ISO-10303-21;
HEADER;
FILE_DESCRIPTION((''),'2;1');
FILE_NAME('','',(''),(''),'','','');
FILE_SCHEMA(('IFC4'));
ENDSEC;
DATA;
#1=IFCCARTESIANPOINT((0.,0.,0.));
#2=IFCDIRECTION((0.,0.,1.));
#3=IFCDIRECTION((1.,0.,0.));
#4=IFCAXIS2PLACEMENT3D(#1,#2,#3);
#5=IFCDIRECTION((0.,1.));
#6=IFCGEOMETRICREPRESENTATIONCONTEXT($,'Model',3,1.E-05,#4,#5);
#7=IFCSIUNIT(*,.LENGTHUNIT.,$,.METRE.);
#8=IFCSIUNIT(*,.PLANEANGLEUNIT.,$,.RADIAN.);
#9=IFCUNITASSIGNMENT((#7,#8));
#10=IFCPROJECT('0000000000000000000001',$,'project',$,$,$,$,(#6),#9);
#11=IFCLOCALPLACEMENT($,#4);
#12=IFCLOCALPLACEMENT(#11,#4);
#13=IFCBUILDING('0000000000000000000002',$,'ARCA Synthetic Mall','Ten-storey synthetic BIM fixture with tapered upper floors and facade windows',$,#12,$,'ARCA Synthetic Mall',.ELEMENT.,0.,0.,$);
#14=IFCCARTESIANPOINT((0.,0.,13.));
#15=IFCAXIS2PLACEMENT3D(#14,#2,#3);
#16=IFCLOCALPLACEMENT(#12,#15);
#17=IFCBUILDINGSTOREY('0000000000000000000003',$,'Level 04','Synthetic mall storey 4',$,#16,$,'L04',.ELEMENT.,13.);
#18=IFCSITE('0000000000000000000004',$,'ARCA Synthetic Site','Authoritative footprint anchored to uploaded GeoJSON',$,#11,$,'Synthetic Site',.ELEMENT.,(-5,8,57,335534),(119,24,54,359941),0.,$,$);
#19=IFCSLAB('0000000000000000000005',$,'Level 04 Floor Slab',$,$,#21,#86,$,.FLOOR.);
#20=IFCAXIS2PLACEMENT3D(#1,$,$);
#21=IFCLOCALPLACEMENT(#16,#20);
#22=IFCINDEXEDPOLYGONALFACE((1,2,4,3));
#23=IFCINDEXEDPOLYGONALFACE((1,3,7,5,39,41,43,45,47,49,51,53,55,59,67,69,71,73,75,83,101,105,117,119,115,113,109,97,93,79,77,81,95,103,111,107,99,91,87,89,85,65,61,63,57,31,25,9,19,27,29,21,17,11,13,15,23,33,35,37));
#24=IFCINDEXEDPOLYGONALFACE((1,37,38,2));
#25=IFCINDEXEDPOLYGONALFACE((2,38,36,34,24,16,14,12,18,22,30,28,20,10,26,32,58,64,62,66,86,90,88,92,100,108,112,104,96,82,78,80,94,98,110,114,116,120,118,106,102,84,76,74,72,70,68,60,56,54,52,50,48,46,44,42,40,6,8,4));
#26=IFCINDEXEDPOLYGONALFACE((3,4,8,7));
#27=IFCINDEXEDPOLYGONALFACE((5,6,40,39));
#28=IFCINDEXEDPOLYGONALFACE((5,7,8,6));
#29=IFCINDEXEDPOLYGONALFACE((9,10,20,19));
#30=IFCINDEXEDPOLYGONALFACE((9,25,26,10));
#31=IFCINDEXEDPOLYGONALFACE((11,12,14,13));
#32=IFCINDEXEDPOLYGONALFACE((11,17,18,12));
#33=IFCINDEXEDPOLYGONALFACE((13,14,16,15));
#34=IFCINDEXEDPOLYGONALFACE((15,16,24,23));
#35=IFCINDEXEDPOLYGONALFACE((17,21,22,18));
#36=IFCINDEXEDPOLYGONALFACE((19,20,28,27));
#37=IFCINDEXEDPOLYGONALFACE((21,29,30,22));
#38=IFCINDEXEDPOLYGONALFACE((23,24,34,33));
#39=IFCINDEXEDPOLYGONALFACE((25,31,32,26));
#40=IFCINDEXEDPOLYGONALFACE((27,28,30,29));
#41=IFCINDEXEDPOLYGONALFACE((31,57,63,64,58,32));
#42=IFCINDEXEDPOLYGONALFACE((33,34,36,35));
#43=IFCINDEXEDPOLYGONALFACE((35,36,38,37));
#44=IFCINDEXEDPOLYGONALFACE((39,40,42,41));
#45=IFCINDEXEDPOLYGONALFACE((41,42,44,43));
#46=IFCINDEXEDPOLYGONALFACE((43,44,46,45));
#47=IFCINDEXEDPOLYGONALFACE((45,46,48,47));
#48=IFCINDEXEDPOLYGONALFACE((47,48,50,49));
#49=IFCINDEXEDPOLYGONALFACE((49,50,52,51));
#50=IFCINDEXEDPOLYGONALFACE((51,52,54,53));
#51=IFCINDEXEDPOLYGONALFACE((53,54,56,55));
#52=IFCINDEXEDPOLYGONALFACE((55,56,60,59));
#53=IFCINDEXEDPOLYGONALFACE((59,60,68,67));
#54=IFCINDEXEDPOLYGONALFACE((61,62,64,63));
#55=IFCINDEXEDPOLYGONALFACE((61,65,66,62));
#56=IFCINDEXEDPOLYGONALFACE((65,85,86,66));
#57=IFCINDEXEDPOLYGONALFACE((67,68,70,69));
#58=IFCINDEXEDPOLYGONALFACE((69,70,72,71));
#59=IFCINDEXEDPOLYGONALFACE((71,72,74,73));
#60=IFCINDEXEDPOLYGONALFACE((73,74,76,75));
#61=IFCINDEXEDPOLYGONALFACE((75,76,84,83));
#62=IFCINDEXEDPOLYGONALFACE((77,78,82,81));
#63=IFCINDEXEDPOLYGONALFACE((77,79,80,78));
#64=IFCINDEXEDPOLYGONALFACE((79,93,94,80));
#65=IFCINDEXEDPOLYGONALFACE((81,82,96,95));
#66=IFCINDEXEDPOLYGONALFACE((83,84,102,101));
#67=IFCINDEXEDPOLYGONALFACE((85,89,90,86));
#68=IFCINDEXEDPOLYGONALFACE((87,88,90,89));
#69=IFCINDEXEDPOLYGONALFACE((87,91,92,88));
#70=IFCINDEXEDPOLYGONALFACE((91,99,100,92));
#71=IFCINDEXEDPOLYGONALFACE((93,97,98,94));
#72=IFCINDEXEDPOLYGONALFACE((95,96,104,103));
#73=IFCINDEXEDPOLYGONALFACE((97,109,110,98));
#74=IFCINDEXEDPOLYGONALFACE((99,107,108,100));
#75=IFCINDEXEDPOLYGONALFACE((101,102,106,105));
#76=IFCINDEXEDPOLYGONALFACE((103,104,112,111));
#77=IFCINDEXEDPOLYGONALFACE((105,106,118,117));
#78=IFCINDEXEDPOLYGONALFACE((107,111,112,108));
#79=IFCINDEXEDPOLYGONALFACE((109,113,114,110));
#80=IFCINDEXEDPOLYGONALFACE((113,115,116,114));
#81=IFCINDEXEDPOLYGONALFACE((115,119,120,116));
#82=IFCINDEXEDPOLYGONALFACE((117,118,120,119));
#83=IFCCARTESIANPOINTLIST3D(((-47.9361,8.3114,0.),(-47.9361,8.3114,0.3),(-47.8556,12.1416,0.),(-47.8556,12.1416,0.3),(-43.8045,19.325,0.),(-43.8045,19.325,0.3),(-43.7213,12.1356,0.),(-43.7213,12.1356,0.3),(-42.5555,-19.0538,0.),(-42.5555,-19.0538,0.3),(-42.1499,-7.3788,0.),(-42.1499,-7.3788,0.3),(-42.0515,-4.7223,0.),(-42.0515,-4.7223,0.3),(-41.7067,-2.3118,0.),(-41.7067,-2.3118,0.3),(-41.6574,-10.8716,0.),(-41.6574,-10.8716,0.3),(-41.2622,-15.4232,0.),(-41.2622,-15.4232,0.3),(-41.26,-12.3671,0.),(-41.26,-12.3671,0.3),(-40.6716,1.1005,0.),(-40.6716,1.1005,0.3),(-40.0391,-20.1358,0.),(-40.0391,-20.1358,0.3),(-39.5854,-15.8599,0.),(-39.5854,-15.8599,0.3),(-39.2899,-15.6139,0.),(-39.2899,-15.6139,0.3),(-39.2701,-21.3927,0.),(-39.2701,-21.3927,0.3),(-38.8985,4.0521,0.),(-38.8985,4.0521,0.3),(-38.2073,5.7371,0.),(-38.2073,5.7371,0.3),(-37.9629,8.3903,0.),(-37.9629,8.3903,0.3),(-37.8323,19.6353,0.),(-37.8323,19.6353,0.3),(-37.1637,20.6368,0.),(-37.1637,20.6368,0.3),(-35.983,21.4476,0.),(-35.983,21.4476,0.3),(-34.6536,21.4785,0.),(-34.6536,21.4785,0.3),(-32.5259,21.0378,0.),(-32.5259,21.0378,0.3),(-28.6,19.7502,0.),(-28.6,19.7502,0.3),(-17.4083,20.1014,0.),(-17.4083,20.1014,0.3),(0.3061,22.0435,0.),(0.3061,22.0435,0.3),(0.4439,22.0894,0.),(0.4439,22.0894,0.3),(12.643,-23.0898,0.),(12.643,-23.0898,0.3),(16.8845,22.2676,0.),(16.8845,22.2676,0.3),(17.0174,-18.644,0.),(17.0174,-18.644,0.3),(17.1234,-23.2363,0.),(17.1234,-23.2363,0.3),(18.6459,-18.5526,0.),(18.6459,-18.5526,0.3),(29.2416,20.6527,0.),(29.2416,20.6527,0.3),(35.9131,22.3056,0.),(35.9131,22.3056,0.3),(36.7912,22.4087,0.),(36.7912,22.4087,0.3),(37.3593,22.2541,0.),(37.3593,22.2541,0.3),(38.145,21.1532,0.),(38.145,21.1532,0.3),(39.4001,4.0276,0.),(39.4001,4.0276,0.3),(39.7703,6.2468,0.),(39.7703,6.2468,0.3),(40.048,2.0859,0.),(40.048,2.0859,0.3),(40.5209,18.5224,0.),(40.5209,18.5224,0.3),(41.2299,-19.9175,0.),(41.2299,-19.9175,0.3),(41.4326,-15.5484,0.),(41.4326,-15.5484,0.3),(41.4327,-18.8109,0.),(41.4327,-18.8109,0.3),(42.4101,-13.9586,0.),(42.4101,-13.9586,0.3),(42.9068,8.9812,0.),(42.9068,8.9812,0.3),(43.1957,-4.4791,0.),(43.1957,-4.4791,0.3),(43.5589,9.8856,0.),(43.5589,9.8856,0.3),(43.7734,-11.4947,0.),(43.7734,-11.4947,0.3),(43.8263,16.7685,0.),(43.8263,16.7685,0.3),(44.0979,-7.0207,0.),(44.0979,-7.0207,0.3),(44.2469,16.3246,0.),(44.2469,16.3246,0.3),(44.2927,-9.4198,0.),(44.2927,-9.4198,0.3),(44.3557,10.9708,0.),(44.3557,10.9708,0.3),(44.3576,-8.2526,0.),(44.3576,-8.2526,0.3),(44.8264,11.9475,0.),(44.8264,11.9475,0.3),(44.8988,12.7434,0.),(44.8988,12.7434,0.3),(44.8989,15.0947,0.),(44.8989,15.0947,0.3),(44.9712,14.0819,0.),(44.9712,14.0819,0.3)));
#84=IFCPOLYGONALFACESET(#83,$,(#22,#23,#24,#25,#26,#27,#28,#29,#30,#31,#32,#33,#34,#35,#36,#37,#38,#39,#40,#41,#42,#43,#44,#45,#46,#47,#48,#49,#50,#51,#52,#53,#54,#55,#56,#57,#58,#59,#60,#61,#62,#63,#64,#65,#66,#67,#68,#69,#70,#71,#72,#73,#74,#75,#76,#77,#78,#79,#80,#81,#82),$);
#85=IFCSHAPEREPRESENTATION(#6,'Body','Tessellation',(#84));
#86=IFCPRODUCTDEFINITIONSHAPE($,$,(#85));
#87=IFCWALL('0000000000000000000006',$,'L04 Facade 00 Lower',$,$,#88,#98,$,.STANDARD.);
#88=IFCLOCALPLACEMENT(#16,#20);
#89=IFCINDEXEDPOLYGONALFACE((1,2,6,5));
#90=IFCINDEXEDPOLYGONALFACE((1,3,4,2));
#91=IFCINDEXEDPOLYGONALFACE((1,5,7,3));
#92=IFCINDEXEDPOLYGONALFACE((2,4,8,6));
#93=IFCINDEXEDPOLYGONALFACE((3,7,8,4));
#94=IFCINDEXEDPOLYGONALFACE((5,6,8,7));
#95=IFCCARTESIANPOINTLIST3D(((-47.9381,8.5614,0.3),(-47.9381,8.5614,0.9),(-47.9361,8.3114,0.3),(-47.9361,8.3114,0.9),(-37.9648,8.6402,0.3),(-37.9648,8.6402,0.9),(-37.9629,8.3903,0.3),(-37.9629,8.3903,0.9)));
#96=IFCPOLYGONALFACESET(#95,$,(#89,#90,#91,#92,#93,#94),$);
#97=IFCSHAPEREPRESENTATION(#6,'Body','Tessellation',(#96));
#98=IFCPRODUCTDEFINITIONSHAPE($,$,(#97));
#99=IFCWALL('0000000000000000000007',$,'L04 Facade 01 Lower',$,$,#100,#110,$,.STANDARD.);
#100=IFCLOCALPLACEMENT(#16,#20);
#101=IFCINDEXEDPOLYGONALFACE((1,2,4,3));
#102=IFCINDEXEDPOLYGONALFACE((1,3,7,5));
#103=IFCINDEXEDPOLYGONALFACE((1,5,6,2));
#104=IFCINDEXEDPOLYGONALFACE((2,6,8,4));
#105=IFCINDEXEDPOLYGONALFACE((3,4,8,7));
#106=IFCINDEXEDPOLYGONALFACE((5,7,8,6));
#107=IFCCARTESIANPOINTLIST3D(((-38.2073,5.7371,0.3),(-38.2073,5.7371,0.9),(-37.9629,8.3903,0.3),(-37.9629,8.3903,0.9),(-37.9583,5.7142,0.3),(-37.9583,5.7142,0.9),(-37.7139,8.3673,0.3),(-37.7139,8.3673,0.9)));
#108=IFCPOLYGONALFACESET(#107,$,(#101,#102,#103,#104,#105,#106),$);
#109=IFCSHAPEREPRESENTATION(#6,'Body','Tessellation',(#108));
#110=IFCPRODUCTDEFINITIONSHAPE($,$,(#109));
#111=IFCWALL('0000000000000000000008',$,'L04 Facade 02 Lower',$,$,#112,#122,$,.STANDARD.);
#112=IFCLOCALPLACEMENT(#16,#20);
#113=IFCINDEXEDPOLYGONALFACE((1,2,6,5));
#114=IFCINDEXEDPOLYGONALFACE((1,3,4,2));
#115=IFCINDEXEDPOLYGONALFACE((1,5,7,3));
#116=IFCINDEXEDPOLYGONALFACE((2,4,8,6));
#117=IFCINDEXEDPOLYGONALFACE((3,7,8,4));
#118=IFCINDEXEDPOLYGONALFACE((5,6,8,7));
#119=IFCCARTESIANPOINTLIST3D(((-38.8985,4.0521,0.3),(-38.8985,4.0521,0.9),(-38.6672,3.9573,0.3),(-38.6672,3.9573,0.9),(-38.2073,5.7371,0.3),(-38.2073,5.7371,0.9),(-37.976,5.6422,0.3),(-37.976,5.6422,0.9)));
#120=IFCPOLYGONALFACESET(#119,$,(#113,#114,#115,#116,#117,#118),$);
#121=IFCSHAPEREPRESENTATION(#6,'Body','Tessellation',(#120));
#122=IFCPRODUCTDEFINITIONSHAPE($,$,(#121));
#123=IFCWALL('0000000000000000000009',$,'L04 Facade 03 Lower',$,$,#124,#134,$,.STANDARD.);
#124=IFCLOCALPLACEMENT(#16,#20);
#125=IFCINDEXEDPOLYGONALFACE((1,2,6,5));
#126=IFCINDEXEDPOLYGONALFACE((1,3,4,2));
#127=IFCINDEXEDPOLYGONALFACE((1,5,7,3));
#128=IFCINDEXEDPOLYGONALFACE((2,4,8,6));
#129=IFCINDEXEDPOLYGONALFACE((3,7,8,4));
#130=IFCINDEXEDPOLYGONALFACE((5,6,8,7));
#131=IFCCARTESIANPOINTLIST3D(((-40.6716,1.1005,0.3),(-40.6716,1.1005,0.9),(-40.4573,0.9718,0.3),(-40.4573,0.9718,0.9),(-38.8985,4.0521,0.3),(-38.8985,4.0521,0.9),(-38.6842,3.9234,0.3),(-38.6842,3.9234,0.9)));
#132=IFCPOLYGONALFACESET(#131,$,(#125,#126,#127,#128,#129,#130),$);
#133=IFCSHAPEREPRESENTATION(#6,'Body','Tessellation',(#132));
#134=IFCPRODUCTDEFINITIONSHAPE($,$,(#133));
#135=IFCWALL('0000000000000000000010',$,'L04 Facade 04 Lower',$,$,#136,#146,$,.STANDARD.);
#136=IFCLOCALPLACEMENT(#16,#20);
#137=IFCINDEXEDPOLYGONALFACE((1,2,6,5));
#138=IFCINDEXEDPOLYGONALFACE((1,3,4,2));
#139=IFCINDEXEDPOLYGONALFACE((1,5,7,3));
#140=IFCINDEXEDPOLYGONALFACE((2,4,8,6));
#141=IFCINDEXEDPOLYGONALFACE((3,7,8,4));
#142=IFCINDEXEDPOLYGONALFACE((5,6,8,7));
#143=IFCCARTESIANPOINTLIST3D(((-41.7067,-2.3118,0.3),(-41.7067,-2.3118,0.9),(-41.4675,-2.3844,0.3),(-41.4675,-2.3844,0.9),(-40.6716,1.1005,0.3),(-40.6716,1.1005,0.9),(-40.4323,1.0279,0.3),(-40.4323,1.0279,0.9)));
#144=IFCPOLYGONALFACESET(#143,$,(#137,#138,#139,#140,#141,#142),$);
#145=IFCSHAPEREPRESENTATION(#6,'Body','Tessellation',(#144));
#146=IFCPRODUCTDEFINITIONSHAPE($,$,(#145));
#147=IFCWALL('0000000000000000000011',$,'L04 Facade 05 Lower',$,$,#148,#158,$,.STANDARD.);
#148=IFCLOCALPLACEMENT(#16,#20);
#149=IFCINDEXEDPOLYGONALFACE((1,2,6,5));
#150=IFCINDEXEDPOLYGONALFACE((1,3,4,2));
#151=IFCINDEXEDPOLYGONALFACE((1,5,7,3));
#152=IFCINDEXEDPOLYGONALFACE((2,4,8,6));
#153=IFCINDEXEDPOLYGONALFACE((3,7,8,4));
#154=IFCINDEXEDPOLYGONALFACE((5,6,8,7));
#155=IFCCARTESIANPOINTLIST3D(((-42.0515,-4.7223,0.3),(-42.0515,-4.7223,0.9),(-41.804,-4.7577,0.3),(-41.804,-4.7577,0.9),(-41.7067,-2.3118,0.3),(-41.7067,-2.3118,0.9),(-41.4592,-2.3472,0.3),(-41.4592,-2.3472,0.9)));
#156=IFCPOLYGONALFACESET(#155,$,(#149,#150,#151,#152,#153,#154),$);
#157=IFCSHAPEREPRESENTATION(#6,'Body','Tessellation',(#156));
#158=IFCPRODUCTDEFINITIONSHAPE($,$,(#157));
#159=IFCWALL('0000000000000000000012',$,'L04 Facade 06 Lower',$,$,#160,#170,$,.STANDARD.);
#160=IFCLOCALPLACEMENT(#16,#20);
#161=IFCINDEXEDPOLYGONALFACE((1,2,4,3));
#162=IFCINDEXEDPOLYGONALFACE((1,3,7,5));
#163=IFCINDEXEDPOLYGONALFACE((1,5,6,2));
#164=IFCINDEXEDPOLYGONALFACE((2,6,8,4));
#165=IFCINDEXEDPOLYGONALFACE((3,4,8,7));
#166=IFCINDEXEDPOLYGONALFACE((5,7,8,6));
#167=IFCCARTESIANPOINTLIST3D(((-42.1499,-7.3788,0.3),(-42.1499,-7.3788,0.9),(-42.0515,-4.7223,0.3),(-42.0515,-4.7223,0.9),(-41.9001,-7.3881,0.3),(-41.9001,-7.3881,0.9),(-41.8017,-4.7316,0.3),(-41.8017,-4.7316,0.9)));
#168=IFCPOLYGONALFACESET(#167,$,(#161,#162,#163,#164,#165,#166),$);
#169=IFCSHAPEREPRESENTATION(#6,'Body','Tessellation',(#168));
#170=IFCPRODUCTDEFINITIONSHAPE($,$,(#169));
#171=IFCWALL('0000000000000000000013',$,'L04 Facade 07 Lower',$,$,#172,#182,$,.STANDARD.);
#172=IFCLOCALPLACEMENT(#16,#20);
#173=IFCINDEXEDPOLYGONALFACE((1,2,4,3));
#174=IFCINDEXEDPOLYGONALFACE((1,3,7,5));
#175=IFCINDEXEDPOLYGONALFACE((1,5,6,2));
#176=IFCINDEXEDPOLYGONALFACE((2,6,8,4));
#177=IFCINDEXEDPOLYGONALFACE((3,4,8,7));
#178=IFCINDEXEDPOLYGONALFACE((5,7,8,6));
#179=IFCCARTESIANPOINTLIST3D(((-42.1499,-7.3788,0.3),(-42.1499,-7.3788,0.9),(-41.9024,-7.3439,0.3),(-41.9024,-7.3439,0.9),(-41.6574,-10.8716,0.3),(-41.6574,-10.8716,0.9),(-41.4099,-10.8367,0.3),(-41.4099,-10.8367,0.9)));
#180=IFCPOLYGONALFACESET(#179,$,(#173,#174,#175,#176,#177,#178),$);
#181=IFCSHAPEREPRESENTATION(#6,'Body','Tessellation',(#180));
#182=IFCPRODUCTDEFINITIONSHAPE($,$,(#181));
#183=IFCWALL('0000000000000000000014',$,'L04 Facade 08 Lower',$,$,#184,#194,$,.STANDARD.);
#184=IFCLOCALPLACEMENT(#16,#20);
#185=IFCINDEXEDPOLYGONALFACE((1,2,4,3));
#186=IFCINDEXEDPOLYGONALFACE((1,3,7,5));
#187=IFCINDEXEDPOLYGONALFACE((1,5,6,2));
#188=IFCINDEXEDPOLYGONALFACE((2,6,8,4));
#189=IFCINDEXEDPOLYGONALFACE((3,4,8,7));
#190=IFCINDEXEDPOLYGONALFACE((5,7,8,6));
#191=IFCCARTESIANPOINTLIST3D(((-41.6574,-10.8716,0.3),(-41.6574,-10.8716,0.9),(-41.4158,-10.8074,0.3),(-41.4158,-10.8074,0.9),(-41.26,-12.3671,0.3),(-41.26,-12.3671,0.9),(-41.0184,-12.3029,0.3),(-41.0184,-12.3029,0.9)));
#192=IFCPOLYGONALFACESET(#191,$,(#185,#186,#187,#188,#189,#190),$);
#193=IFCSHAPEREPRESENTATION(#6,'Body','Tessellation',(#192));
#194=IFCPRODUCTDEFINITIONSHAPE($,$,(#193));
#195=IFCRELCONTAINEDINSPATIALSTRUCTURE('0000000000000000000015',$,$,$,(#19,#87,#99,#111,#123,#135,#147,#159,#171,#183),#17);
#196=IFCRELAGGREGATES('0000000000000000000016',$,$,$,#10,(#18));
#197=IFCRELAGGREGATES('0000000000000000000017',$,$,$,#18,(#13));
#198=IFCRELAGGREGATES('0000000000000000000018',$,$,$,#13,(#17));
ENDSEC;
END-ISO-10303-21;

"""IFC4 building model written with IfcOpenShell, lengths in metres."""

from ifc_helpers import new_model, si_unit, direction, frame, origin_with_axes, place, context, project, spatial, polyline, outline, extrude, element, save


model = new_model("IFC4")

# Units and contexts
model_context = context("Model", 3, precision=1e-05, world=origin_with_axes(), true_north=direction((0.0, 1.0)))
ifc_project = project(units=[si_unit("LENGTHUNIT", "METRE"), si_unit("PLANEANGLEUNIT", "RADIAN")], contexts=[model_context])

# Site, building, storey
site_placement = place(None, origin_with_axes())
site = spatial("IfcSite", under=ifc_project, at=site_placement, Name="ARCA Synthetic Site", Description="Authoritative footprint anchored to uploaded GeoJSON", LongName="Synthetic Site", CompositionType="ELEMENT", RefLatitude=(-5, 8, 57, 335534), RefLongitude=(119, 24, 54, 359941), RefElevation=0.0)
building_placement = place(site_placement, origin_with_axes())
building = spatial("IfcBuilding", under=site, at=building_placement, Name="ARCA Synthetic Mall", Description="Ten-storey synthetic BIM fixture with tapered upper floors and facade windows", LongName="ARCA Synthetic Mall", CompositionType="ELEMENT", ElevationOfRefHeight=0.0, ElevationOfTerrain=0.0)
storey_placement = place(building_placement, frame((0.0, 0.0, 13.0), z_axis=(0.0, 0.0, 1.0), x_axis=(1.0, 0.0, 0.0)))
storey = spatial("IfcBuildingStorey", under=building, at=storey_placement, Name="Level 04", Description="Synthetic mall storey 4", LongName="L04", CompositionType="ELEMENT", Elevation=13.0)

# Slab
slab_placement = place(storey_placement, origin_with_axes())
element("IfcSlab", 1, at=slab_placement, inside=storey, Name="Level 04 Floor Slab", PredefinedType="FLOOR", context=model_context, shape_type="SweptSolid", body=[
    extrude(outline(polyline([(-47.9361, 8.3114), (-37.9629, 8.3903), (-38.2073, 5.7371), (-38.8985, 4.0521), (-40.6716, 1.1005), (-41.7067, -2.3118), (-42.0515, -4.7223), (-42.1499, -7.3788), (-41.6574, -10.8716), (-41.26, -12.3671), (-39.2899, -15.6139), (-39.5854, -15.8599), (-41.2622, -15.4232), (-42.5555, -19.0538), (-40.0391, -20.1358), (-39.2701, -21.3927), (12.6431, -23.0898), (17.1234, -23.2363), (17.0174, -18.644), (18.6459, -18.5526), (41.2299, -19.9175), (41.4327, -18.8109), (41.4326, -15.5484), (42.4101, -13.9586), (43.7734, -11.4947), (44.2927, -9.4198), (44.3576, -8.2526), (44.0979, -7.0207), (43.1957, -4.4791), (40.048, 2.0859), (39.4001, 4.0276), (39.7703, 6.2468), (42.9068, 8.9812), (43.5589, 9.8856), (44.3557, 10.9708), (44.8264, 11.9475), (44.8988, 12.7434), (44.9712, 14.0819), (44.8989, 15.0947), (44.2469, 16.3246), (43.8263, 16.7685), (40.5209, 18.5224), (38.145, 21.1532), (37.3593, 22.2541), (36.7912, 22.4087), (35.9131, 22.3056), (29.2416, 20.6527), (16.8845, 22.2676), (0.4439, 22.0894), (0.3061, 22.0435), (-17.4083, 20.1014), (-28.6, 19.7502), (-32.5259, 21.0378), (-34.6536, 21.4785), (-35.983, 21.4475), (-37.1637, 20.6368), (-37.8323, 19.6353), (-43.8045, 19.325), (-43.7213, 12.1356), (-47.8556, 12.1416), (-47.9361, 8.3114)])), origin_with_axes(), (0.0, 0.0, 1.0), 0.3),
])

# Walls
wall_1_placement = place(storey_placement, frame((0.0, 0.0, 0.3), z_axis=(0.0, 0.0, 1.0), x_axis=(1.0, 0.0, 0.0)))
element("IfcWall", 2, at=wall_1_placement, inside=storey, Name="L04 Facade 00 Lower", PredefinedType="STANDARD", context=model_context, shape_type="SweptSolid", body=[
    extrude(outline(polyline([(-47.9361, 8.3114), (-37.9629, 8.3903), (-37.9648, 8.6402), (-47.9381, 8.5614), (-47.9361, 8.3114)])), origin_with_axes(), (0.0, 0.0, 1.0), 0.6),
])
wall_2_placement = place(storey_placement, frame((0.0, 0.0, 0.3), z_axis=(0.0, 0.0, 1.0), x_axis=(1.0, 0.0, 0.0)))
element("IfcWall", 3, at=wall_2_placement, inside=storey, Name="L04 Facade 01 Lower", PredefinedType="STANDARD", context=model_context, shape_type="SweptSolid", body=[
    extrude(outline(polyline([(-37.9629, 8.3903), (-38.2073, 5.7371), (-37.9583, 5.7142), (-37.7139, 8.3673), (-37.9629, 8.3903)])), origin_with_axes(), (0.0, 0.0, 1.0), 0.6),
])
wall_3_placement = place(storey_placement, frame((0.0, 0.0, 0.3), z_axis=(0.0, 0.0, 1.0), x_axis=(1.0, 0.0, 0.0)))
element("IfcWall", 4, at=wall_3_placement, inside=storey, Name="L04 Facade 02 Lower", PredefinedType="STANDARD", context=model_context, shape_type="SweptSolid", body=[
    extrude(outline(polyline([(-38.2073, 5.7371), (-38.8985, 4.0521), (-38.6672, 3.9573), (-37.976, 5.6422), (-38.2073, 5.7371)])), origin_with_axes(), (0.0, 0.0, 1.0), 0.6),
])
wall_4_placement = place(storey_placement, frame((0.0, 0.0, 0.3), z_axis=(0.0, 0.0, 1.0), x_axis=(1.0, 0.0, 0.0)))
element("IfcWall", 5, at=wall_4_placement, inside=storey, Name="L04 Facade 03 Lower", PredefinedType="STANDARD", context=model_context, shape_type="SweptSolid", body=[
    extrude(outline(polyline([(-38.8985, 4.0521), (-40.6716, 1.1005), (-40.4573, 0.9718), (-38.6842, 3.9234), (-38.8985, 4.0521)])), origin_with_axes(), (0.0, 0.0, 1.0), 0.6),
])
wall_5_placement = place(storey_placement, frame((0.0, 0.0, 0.3), z_axis=(0.0, 0.0, 1.0), x_axis=(1.0, 0.0, 0.0)))
element("IfcWall", 6, at=wall_5_placement, inside=storey, Name="L04 Facade 04 Lower", PredefinedType="STANDARD", context=model_context, shape_type="SweptSolid", body=[
    extrude(outline(polyline([(-40.6716, 1.1005), (-41.7067, -2.3118), (-41.4675, -2.3844), (-40.4323, 1.0279), (-40.6716, 1.1005)])), origin_with_axes(), (0.0, 0.0, 1.0), 0.6),
])
wall_6_placement = place(storey_placement, frame((0.0, 0.0, 0.3), z_axis=(0.0, 0.0, 1.0), x_axis=(1.0, 0.0, 0.0)))
element("IfcWall", 7, at=wall_6_placement, inside=storey, Name="L04 Facade 05 Lower", PredefinedType="STANDARD", context=model_context, shape_type="SweptSolid", body=[
    extrude(outline(polyline([(-41.7067, -2.3118), (-42.0515, -4.7223), (-41.804, -4.7577), (-41.4592, -2.3472), (-41.7067, -2.3118)])), origin_with_axes(), (0.0, 0.0, 1.0), 0.6),
])
wall_7_placement = place(storey_placement, frame((0.0, 0.0, 0.3), z_axis=(0.0, 0.0, 1.0), x_axis=(1.0, 0.0, 0.0)))
element("IfcWall", 8, at=wall_7_placement, inside=storey, Name="L04 Facade 06 Lower", PredefinedType="STANDARD", context=model_context, shape_type="SweptSolid", body=[
    extrude(outline(polyline([(-42.0515, -4.7223), (-42.1499, -7.3788), (-41.9001, -7.3881), (-41.8017, -4.7316), (-42.0515, -4.7223)])), origin_with_axes(), (0.0, 0.0, 1.0), 0.6),
])
wall_8_placement = place(storey_placement, frame((0.0, 0.0, 0.3), z_axis=(0.0, 0.0, 1.0), x_axis=(1.0, 0.0, 0.0)))
element("IfcWall", 9, at=wall_8_placement, inside=storey, Name="L04 Facade 07 Lower", PredefinedType="STANDARD", context=model_context, shape_type="SweptSolid", body=[
    extrude(outline(polyline([(-42.1499, -7.3788), (-41.6574, -10.8716), (-41.4099, -10.8367), (-41.9024, -7.3439), (-42.1499, -7.3788)])), origin_with_axes(), (0.0, 0.0, 1.0), 0.6),
])
wall_9_placement = place(storey_placement, frame((0.0, 0.0, 0.3), z_axis=(0.0, 0.0, 1.0), x_axis=(1.0, 0.0, 0.0)))
element("IfcWall", 10, at=wall_9_placement, inside=storey, Name="L04 Facade 08 Lower", PredefinedType="STANDARD", context=model_context, shape_type="SweptSolid", body=[
    extrude(outline(polyline([(-41.6574, -10.8716), (-41.26, -12.3671), (-41.0184, -12.3029), (-41.4158, -10.8074), (-41.6574, -10.8716)])), origin_with_axes(), (0.0, 0.0, 1.0), 0.6),
])

save(model, "model.ifc")
